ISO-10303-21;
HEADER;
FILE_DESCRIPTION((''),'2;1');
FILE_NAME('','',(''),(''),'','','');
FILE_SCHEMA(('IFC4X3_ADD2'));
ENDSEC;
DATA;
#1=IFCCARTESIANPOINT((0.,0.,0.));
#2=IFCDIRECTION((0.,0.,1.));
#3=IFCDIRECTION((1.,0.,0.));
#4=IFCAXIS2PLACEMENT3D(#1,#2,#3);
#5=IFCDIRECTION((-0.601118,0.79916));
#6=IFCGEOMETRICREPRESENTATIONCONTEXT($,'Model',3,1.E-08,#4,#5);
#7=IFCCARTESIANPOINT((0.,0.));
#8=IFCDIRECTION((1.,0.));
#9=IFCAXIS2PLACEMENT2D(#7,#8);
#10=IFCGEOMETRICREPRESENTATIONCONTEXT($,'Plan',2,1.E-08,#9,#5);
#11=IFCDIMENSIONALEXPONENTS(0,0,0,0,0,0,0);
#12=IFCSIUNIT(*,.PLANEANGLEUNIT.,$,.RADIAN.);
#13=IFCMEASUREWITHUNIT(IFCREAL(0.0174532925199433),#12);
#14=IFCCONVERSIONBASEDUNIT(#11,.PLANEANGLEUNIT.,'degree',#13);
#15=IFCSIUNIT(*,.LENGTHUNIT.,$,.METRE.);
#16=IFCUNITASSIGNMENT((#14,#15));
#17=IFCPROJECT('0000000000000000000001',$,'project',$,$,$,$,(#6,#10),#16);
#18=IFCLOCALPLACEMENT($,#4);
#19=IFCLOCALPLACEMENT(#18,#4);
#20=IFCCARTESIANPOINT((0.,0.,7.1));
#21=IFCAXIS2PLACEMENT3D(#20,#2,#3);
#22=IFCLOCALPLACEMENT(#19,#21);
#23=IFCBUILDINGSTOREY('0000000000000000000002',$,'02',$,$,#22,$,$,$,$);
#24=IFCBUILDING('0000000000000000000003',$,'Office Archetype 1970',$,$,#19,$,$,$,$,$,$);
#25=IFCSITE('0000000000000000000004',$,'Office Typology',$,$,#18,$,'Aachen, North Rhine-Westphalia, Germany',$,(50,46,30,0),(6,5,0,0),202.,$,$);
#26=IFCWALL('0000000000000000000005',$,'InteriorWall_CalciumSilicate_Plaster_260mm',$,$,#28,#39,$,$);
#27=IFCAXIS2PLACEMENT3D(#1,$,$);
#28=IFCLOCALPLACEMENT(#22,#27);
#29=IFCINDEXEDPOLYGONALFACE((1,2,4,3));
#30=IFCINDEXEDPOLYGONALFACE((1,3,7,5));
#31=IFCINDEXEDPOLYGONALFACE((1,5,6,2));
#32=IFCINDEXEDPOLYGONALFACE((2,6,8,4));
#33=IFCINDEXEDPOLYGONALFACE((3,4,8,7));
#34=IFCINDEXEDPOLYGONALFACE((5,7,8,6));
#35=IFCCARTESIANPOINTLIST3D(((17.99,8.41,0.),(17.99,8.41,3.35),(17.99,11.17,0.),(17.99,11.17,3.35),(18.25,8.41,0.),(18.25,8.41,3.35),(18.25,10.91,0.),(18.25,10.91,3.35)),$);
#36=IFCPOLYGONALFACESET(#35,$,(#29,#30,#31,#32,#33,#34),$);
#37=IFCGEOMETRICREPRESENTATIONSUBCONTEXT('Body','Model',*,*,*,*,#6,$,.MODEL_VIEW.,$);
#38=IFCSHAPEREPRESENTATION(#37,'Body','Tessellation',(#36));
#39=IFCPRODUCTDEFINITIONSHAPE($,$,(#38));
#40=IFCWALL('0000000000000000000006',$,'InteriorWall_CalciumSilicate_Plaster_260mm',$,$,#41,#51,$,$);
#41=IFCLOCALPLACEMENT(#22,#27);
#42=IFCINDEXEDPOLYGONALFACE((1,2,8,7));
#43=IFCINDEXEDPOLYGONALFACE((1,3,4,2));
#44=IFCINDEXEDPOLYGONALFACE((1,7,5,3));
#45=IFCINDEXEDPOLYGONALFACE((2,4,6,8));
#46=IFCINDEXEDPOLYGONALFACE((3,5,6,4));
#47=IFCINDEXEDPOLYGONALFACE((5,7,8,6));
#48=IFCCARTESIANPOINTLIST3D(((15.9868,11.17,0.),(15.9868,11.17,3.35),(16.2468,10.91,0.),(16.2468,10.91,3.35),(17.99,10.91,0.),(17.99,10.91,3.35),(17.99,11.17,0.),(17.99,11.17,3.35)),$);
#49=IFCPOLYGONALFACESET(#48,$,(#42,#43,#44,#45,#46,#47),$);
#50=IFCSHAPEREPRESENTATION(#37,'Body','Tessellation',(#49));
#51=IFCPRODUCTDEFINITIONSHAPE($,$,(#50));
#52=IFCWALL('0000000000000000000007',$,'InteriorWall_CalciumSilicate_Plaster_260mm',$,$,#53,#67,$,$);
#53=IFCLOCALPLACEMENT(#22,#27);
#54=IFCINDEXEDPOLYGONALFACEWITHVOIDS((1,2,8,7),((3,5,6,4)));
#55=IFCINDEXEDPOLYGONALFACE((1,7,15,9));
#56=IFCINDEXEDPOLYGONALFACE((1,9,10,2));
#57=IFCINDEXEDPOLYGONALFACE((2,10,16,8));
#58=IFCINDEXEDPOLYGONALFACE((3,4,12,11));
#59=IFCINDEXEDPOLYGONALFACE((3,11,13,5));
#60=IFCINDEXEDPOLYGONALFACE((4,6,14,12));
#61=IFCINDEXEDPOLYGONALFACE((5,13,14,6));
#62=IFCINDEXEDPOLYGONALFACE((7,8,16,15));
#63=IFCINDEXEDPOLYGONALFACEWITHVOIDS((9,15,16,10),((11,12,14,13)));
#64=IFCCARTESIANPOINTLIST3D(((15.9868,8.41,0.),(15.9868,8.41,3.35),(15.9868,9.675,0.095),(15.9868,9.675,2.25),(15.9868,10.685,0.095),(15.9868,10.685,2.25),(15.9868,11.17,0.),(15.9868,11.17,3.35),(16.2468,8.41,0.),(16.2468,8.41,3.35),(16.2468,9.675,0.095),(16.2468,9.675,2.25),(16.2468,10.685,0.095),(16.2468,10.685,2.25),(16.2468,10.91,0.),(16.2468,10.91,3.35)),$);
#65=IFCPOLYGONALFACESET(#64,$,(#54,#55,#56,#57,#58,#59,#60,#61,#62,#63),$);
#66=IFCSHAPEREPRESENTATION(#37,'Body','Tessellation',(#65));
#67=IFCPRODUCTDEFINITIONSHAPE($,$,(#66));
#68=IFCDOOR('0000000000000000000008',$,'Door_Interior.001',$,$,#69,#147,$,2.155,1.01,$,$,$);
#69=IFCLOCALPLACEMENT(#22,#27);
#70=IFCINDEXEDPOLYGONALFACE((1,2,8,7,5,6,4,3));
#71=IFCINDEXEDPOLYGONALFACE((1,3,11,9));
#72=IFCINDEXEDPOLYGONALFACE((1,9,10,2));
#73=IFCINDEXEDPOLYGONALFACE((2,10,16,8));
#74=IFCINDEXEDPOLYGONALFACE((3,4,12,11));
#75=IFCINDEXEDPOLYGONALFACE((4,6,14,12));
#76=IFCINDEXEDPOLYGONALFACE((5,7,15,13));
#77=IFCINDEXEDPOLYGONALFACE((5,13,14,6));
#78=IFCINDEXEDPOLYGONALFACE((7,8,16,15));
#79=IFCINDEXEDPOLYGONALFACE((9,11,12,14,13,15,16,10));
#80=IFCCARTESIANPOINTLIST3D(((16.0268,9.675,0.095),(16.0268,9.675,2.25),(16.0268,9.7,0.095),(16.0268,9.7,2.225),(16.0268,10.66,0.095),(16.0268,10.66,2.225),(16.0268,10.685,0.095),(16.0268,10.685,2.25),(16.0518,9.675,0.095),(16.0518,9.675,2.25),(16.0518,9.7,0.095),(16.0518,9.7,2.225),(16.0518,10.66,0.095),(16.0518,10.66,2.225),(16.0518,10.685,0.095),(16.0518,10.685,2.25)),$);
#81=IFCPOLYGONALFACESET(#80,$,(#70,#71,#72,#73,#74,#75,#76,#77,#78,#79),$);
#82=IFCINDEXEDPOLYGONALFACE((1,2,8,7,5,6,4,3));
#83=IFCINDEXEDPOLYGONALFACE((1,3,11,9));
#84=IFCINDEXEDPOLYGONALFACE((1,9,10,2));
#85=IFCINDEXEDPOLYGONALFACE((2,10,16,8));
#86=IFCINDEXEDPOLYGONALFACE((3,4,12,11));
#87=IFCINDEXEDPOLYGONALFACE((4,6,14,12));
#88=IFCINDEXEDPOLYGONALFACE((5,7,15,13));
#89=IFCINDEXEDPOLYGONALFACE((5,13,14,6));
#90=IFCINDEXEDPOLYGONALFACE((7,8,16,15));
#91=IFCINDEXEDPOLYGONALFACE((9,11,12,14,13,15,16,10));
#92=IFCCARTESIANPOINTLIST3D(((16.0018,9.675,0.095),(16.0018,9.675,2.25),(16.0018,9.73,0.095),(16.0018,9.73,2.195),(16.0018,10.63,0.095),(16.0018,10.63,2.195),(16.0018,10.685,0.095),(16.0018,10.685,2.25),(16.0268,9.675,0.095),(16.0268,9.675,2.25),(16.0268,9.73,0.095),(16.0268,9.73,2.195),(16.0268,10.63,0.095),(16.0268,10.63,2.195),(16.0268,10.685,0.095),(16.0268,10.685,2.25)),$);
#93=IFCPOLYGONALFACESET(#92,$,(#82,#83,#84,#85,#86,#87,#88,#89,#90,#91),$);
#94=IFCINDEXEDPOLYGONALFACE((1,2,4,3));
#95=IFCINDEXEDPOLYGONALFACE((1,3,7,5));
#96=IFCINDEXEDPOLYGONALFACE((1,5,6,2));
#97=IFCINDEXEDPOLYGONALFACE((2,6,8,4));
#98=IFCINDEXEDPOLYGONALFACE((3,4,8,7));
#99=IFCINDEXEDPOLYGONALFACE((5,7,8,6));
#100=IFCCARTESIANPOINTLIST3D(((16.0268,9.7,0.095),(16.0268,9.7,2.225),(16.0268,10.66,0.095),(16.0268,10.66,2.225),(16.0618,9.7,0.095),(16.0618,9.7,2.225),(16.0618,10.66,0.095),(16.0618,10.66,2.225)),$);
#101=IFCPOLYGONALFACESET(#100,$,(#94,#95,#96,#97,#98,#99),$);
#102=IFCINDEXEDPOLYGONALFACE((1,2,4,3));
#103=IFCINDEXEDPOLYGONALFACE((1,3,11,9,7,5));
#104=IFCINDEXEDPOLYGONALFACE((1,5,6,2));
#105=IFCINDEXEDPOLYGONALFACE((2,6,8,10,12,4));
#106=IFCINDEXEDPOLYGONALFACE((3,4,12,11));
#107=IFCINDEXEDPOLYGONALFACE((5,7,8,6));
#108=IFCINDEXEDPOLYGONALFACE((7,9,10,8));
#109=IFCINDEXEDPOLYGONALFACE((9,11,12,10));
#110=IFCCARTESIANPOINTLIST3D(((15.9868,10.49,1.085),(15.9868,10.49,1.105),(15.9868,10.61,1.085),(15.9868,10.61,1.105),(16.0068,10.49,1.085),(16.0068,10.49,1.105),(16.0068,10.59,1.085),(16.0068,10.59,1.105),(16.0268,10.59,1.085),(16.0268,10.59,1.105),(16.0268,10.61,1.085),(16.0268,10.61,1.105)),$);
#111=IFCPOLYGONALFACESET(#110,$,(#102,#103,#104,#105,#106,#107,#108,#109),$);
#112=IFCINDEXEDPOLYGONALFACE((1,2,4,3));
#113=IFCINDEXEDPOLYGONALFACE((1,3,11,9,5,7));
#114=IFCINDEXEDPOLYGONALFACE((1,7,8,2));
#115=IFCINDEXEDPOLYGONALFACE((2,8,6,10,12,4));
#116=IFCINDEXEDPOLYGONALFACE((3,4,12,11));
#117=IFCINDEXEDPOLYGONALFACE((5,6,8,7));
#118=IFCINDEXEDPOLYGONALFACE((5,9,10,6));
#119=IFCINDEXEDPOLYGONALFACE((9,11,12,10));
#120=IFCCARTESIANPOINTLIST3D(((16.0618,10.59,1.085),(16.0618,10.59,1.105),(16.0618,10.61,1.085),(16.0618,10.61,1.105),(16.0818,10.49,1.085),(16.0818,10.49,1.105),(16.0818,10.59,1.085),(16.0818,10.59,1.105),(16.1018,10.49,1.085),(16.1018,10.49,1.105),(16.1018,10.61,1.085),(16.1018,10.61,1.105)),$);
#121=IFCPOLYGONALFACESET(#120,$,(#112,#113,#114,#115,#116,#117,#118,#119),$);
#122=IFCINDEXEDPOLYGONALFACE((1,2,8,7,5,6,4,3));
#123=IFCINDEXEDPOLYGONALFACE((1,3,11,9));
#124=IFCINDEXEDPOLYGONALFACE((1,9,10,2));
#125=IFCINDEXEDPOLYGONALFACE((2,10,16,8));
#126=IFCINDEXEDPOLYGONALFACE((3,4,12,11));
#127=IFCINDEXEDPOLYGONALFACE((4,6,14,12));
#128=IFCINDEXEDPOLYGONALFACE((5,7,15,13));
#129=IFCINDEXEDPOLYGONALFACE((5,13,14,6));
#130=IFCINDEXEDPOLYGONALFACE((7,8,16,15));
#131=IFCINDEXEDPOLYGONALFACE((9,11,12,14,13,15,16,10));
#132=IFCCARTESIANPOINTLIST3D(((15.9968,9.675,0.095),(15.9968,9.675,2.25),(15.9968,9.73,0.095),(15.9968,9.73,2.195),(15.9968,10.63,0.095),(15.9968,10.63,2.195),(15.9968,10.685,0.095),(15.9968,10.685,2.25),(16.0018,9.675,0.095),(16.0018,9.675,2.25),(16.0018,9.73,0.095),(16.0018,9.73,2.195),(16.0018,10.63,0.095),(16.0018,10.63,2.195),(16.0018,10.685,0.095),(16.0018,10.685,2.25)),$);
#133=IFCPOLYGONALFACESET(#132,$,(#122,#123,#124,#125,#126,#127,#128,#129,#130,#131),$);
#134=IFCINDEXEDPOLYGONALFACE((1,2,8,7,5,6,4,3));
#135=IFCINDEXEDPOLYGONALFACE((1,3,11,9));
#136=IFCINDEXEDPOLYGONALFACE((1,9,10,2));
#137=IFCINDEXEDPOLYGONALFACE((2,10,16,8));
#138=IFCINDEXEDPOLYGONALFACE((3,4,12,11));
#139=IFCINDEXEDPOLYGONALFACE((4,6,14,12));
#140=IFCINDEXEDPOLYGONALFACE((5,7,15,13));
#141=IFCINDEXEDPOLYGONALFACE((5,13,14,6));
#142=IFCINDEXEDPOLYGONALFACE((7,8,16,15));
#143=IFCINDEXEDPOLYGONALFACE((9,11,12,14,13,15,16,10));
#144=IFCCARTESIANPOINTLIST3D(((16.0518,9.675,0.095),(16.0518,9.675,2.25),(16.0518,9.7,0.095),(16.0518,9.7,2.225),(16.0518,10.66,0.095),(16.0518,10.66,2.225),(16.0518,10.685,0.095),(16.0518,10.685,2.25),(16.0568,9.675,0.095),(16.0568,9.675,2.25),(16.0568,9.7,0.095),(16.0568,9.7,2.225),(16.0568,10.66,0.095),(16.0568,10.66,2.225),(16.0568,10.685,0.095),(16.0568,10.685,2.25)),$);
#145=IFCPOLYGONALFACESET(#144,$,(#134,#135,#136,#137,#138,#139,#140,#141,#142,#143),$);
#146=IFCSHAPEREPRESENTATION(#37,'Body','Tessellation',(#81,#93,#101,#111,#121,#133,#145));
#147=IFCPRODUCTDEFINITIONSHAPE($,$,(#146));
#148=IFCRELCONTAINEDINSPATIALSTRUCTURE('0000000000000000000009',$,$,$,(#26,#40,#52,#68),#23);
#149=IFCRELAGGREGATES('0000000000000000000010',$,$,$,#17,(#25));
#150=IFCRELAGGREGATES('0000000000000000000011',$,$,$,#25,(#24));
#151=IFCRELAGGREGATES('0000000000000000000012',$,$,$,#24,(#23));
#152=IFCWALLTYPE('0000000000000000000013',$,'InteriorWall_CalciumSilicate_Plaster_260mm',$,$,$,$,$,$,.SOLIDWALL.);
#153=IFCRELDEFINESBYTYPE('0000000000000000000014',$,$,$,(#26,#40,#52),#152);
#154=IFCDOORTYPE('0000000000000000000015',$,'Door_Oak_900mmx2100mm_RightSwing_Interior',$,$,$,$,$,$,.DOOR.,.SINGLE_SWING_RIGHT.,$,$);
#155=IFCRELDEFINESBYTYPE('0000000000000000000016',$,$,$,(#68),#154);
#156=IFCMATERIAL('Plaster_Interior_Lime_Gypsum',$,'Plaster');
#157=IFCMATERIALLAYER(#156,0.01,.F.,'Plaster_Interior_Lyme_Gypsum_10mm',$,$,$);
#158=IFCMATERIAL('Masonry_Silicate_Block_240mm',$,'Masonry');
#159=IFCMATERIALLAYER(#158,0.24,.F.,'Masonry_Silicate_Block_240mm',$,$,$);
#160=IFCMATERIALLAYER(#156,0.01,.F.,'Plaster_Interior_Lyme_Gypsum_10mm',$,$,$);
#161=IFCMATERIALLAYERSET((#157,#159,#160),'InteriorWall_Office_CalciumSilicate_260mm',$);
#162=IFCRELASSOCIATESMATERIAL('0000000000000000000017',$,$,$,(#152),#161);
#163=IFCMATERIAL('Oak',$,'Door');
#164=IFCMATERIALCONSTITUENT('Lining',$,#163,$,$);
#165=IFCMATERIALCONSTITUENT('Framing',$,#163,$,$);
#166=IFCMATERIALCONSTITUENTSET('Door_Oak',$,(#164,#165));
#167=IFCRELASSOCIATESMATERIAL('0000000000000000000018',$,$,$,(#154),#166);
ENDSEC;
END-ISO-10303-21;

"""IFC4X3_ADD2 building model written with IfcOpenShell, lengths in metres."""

from ifc_helpers import new_model, entity, si_unit, converted_unit, direction, frame, origin_with_axes, origin_2d_with_axis, place, context, subcontext, project, spatial, line, indexed_curve, outline, extrude, source, transform, mapped, material, layer, layer_set, constituent, constituent_set, type_object, type_shapes, element, fill, save


model = new_model("IFC4X3_ADD2")

# Units and contexts
model_context = context("Model", 3, precision=1e-08, world=origin_with_axes(), true_north=direction((-0.601118, 0.79916)))
plan_context = context("Plan", 2, precision=1e-08, world=origin_2d_with_axis(), true_north=direction((-0.601118, 0.79916)))
body_context = subcontext(model_context, "Body", "Model", "MODEL_VIEW")
ifc_project = project(units=[converted_unit("PLANEANGLEUNIT", "degree", entity("IfcReal", 0.0174532925199433), si_unit("PLANEANGLEUNIT", "RADIAN"), dimensions=[0, 0, 0, 0, 0, 0, 0]), si_unit("LENGTHUNIT", "METRE")], contexts=[model_context, plan_context])

# Site, building, storey
site_placement = place(None, origin_with_axes())
site = spatial("IfcSite", under=ifc_project, at=site_placement, Name="Office Typology", LongName="Aachen, North Rhine-Westphalia, Germany", RefLatitude=(50, 46, 30, 0), RefLongitude=(6, 5, 0, 0), RefElevation=202.0)
building_placement = place(site_placement, origin_with_axes())
building = spatial("IfcBuilding", under=site, at=building_placement, Name="Office Archetype 1970")
storey_placement = place(building_placement, frame((0.0, 0.0, 7.1), z_axis=(0.0, 0.0, 1.0), x_axis=(1.0, 0.0, 0.0)))
storey = spatial("IfcBuildingStorey", under=building, at=storey_placement, Name="02")

# Walls
ifc_material_1 = material(Name="Plaster_Interior_Lime_Gypsum", Category="Plaster")
ifc_layer_1 = layer(ifc_material_1, 0.01, ventilated=False, Name="Plaster_Interior_Lyme_Gypsum_10mm")
ifc_material_2 = material(Name="Masonry_Silicate_Block_240mm", Category="Masonry")
ifc_layer_2 = layer(ifc_material_2, 0.24, ventilated=False, Name="Masonry_Silicate_Block_240mm")
ifc_layer_3 = layer(ifc_material_1, 0.01, ventilated=False, Name="Plaster_Interior_Lyme_Gypsum_10mm")
ifc_layer_set_1 = layer_set([ifc_layer_1, ifc_layer_2, ifc_layer_3], Name="InteriorWall_Office_CalciumSilicate_260mm")
wall_type_1 = type_object("IfcWallType", Name="InteriorWall_CalciumSilicate_Plaster_260mm", PredefinedType="SOLIDWALL", material=ifc_layer_set_1)
wall_1_placement = place(storey_placement, frame((17.99, 11.17, 0.0), z_axis=(0.0, 0.0, 1.0), x_axis=(0.0, -1.0, 0.0)))
element("IfcWall", 1, at=wall_1_placement, inside=storey, type_object=wall_type_1, Name="InteriorWall_CalciumSilicate_Plaster_260mm", context=body_context, shape_type="SweptSolid", body=[
    extrude(outline(indexed_curve([(0.0, 0.0), (0.26, 0.26), (2.76, 0.26), (2.76, 0.0)], segments=[line(1, 2, 3, 4, 1)])), origin_with_axes(), (0.0, 0.0, 1.0), 3.35),
])
wall_2_placement = place(storey_placement, frame((17.99, 11.17, 0.0), z_axis=(0.0, 0.0, 1.0), x_axis=(-1.0, 0.0, 0.0)))
element("IfcWall", 2, at=wall_2_placement, inside=storey, type_object=wall_type_1, Name="InteriorWall_CalciumSilicate_Plaster_260mm", context=body_context, shape_type="SweptSolid", body=[
    extrude(outline(indexed_curve([(0.0, 0.0), (0.0, 0.26), (1.7432, 0.26), (2.0032, 0.0)], segments=[line(1, 2, 3, 4, 1)])), origin_with_axes(), (0.0, 0.0, 1.0), 3.35),
])

# Wall, opening, door
wall_3_placement = place(storey_placement, frame((15.9868, 11.17, 0.0), z_axis=(0.0, 0.0, 1.0), x_axis=(0.0, -1.0, 0.0)))
wall_3 = element("IfcWall", 3, at=wall_3_placement, inside=storey, type_object=wall_type_1, Name="InteriorWall_CalciumSilicate_Plaster_260mm", context=body_context, shape_type="SweptSolid", body=[
    extrude(outline(indexed_curve([(0.0, 0.0), (0.26, 0.26), (2.76, 0.26), (2.76, 0.0)], segments=[line(1, 2, 3, 4, 1)])), origin_with_axes(), (0.0, 0.0, 1.0), 3.35),
])
shared_shape_1 = source(origin_with_axes(), body_context, "Body", "SweptSolid", [
    extrude(outline(indexed_curve([(0.0, 0.0), (1.01, 0.0), (1.01, 2.155), (0.0, 2.155), (0.0, 0.0)])), frame((0.0, -0.015, 0.0), z_axis=(0.0, -1.0, 0.0), x_axis=(1.0, 0.0, 0.0)), (0.0, 0.0, -1.0), 0.26),
])
opening_1_placement = place(wall_3_placement, frame((0.485, 0.015, 0.095), z_axis=(0.0, 0.0, 1.0), x_axis=(1.0, 0.0, 0.0)))
opening_1 = element("IfcOpeningElement", 4, at=opening_1_placement, cuts=wall_3, PredefinedType="OPENING", context=body_context, shape_type="MappedRepresentation", body=[
    mapped(shared_shape_1, transform((0.0, 0.0, 0.0), x_axis=(1.0, 0.0, 0.0), y_axis=(0.0, 1.0, 0.0), z_axis=(0.0, 0.0, 1.0), scale=1.0)),
])
ifc_material_3 = material(Name="Oak", Category="Door")
ifc_constituent_1 = constituent(ifc_material_3, Name="Lining")
ifc_constituent_2 = constituent(ifc_material_3, Name="Framing")
ifc_constituent_set_1 = constituent_set(constituents=[ifc_constituent_1, ifc_constituent_2], Name="Door_Oak")
door_type_1 = type_object("IfcDoorType", Name="Door_Oak_900mmx2100mm_RightSwing_Interior", OperationType="SINGLE_SWING_RIGHT", PredefinedType="DOOR", material=ifc_constituent_set_1)
shared_shape_2 = source(origin_with_axes(), body_context, "Body", "SweptSolid", [
    extrude(outline(indexed_curve([(0.0, 0.0), (0.0, 2.155), (1.01, 2.155), (1.01, 0.0), (0.985, 0.0), (0.985, 2.13), (0.025, 2.13), (0.025, 0.0)], segments=[line(1, 2, 3, 4, 5, 6, 7, 8, 1)])), frame((0.0, 0.025, 0.0), z_axis=(0.0, -1.0, 0.0), x_axis=(1.0, 0.0, 0.0)), (0.0, 0.0, -1.0), 0.025),
    extrude(outline(indexed_curve([(0.0, 0.0), (0.0, 2.155), (1.01, 2.155), (1.01, 0.0), (0.955, 0.0), (0.955, 2.1), (0.055, 2.1), (0.055, 0.0)], segments=[line(1, 2, 3, 4, 5, 6, 7, 8, 1)])), frame((0.0, 0.0, 0.0), z_axis=(0.0, -1.0, 0.0), x_axis=(1.0, 0.0, 0.0)), (0.0, 0.0, -1.0), 0.025),
    extrude(outline(indexed_curve([(0.0, 0.0), (0.96, 0.0), (0.96, 0.035), (0.0, 0.035)], segments=[line(1, 2, 3, 4, 1)])), frame((0.025, 0.025, 0.0), z_axis=(0.0, 0.0, 1.0), x_axis=(1.0, 0.0, 0.0)), (0.0, 0.0, 1.0), 2.13),
    extrude(outline(indexed_curve([(0.0, 0.0), (0.0, -0.04), (0.12, -0.04), (0.12, -0.02), (0.02, -0.02), (0.02, 0.0)], segments=[line(1, 2, 3, 4, 5, 6, 1)])), frame((0.075, 0.025, 0.99), z_axis=(0.0, 0.0, 1.0), x_axis=(1.0, 0.0, 0.0)), (0.0, 0.0, 1.0), 0.02),
    extrude(outline(indexed_curve([(0.0, 0.0), (0.0, 0.04), (0.12, 0.04), (0.12, 0.02), (0.02, 0.02), (0.02, 0.0)], segments=[line(1, 2, 3, 4, 5, 6, 1)])), frame((0.075, 0.06, 0.99), z_axis=(0.0, 0.0, 1.0), x_axis=(1.0, 0.0, 0.0)), (0.0, 0.0, 1.0), 0.02),
    extrude(outline(indexed_curve([(0.0, 0.0), (0.0, 2.155), (1.01, 2.155), (1.01, 0.0), (0.955, 0.0), (0.955, 2.1), (0.055, 2.1), (0.055, 0.0)], segments=[line(1, 2, 3, 4, 5, 6, 7, 8, 1)])), frame((0.0, -0.005, 0.0), z_axis=(0.0, -1.0, 0.0), x_axis=(1.0, 0.0, 0.0)), (0.0, 0.0, -1.0), 0.005),
    extrude(outline(indexed_curve([(0.0, 0.0), (0.0, 2.155), (1.01, 2.155), (1.01, 0.0), (0.985, 0.0), (0.985, 2.13), (0.025, 2.13), (0.025, 0.0)], segments=[line(1, 2, 3, 4, 5, 6, 7, 8, 1)])), frame((0.0, 0.05, 0.0), z_axis=(0.0, -1.0, 0.0), x_axis=(1.0, 0.0, 0.0)), (0.0, 0.0, -1.0), 0.005),
])
type_shapes(door_type_1, [shared_shape_2])
door_1_placement = place(opening_1_placement, origin_with_axes())
door_1 = element("IfcDoor", 5, at=door_1_placement, inside=storey, type_object=door_type_1, Name="Door_Interior.001", OverallHeight=2.155, OverallWidth=1.01, context=body_context, shape_type="MappedRepresentation", body=[
    mapped(shared_shape_2, transform((0.0, 0.0, 0.0), x_axis=(1.0, 0.0, 0.0), y_axis=(0.0, 1.0, 0.0), z_axis=(0.0, 0.0, 1.0), scale=1.0)),
])
fill(opening_1, door_1)

save(model, "model.ifc")
